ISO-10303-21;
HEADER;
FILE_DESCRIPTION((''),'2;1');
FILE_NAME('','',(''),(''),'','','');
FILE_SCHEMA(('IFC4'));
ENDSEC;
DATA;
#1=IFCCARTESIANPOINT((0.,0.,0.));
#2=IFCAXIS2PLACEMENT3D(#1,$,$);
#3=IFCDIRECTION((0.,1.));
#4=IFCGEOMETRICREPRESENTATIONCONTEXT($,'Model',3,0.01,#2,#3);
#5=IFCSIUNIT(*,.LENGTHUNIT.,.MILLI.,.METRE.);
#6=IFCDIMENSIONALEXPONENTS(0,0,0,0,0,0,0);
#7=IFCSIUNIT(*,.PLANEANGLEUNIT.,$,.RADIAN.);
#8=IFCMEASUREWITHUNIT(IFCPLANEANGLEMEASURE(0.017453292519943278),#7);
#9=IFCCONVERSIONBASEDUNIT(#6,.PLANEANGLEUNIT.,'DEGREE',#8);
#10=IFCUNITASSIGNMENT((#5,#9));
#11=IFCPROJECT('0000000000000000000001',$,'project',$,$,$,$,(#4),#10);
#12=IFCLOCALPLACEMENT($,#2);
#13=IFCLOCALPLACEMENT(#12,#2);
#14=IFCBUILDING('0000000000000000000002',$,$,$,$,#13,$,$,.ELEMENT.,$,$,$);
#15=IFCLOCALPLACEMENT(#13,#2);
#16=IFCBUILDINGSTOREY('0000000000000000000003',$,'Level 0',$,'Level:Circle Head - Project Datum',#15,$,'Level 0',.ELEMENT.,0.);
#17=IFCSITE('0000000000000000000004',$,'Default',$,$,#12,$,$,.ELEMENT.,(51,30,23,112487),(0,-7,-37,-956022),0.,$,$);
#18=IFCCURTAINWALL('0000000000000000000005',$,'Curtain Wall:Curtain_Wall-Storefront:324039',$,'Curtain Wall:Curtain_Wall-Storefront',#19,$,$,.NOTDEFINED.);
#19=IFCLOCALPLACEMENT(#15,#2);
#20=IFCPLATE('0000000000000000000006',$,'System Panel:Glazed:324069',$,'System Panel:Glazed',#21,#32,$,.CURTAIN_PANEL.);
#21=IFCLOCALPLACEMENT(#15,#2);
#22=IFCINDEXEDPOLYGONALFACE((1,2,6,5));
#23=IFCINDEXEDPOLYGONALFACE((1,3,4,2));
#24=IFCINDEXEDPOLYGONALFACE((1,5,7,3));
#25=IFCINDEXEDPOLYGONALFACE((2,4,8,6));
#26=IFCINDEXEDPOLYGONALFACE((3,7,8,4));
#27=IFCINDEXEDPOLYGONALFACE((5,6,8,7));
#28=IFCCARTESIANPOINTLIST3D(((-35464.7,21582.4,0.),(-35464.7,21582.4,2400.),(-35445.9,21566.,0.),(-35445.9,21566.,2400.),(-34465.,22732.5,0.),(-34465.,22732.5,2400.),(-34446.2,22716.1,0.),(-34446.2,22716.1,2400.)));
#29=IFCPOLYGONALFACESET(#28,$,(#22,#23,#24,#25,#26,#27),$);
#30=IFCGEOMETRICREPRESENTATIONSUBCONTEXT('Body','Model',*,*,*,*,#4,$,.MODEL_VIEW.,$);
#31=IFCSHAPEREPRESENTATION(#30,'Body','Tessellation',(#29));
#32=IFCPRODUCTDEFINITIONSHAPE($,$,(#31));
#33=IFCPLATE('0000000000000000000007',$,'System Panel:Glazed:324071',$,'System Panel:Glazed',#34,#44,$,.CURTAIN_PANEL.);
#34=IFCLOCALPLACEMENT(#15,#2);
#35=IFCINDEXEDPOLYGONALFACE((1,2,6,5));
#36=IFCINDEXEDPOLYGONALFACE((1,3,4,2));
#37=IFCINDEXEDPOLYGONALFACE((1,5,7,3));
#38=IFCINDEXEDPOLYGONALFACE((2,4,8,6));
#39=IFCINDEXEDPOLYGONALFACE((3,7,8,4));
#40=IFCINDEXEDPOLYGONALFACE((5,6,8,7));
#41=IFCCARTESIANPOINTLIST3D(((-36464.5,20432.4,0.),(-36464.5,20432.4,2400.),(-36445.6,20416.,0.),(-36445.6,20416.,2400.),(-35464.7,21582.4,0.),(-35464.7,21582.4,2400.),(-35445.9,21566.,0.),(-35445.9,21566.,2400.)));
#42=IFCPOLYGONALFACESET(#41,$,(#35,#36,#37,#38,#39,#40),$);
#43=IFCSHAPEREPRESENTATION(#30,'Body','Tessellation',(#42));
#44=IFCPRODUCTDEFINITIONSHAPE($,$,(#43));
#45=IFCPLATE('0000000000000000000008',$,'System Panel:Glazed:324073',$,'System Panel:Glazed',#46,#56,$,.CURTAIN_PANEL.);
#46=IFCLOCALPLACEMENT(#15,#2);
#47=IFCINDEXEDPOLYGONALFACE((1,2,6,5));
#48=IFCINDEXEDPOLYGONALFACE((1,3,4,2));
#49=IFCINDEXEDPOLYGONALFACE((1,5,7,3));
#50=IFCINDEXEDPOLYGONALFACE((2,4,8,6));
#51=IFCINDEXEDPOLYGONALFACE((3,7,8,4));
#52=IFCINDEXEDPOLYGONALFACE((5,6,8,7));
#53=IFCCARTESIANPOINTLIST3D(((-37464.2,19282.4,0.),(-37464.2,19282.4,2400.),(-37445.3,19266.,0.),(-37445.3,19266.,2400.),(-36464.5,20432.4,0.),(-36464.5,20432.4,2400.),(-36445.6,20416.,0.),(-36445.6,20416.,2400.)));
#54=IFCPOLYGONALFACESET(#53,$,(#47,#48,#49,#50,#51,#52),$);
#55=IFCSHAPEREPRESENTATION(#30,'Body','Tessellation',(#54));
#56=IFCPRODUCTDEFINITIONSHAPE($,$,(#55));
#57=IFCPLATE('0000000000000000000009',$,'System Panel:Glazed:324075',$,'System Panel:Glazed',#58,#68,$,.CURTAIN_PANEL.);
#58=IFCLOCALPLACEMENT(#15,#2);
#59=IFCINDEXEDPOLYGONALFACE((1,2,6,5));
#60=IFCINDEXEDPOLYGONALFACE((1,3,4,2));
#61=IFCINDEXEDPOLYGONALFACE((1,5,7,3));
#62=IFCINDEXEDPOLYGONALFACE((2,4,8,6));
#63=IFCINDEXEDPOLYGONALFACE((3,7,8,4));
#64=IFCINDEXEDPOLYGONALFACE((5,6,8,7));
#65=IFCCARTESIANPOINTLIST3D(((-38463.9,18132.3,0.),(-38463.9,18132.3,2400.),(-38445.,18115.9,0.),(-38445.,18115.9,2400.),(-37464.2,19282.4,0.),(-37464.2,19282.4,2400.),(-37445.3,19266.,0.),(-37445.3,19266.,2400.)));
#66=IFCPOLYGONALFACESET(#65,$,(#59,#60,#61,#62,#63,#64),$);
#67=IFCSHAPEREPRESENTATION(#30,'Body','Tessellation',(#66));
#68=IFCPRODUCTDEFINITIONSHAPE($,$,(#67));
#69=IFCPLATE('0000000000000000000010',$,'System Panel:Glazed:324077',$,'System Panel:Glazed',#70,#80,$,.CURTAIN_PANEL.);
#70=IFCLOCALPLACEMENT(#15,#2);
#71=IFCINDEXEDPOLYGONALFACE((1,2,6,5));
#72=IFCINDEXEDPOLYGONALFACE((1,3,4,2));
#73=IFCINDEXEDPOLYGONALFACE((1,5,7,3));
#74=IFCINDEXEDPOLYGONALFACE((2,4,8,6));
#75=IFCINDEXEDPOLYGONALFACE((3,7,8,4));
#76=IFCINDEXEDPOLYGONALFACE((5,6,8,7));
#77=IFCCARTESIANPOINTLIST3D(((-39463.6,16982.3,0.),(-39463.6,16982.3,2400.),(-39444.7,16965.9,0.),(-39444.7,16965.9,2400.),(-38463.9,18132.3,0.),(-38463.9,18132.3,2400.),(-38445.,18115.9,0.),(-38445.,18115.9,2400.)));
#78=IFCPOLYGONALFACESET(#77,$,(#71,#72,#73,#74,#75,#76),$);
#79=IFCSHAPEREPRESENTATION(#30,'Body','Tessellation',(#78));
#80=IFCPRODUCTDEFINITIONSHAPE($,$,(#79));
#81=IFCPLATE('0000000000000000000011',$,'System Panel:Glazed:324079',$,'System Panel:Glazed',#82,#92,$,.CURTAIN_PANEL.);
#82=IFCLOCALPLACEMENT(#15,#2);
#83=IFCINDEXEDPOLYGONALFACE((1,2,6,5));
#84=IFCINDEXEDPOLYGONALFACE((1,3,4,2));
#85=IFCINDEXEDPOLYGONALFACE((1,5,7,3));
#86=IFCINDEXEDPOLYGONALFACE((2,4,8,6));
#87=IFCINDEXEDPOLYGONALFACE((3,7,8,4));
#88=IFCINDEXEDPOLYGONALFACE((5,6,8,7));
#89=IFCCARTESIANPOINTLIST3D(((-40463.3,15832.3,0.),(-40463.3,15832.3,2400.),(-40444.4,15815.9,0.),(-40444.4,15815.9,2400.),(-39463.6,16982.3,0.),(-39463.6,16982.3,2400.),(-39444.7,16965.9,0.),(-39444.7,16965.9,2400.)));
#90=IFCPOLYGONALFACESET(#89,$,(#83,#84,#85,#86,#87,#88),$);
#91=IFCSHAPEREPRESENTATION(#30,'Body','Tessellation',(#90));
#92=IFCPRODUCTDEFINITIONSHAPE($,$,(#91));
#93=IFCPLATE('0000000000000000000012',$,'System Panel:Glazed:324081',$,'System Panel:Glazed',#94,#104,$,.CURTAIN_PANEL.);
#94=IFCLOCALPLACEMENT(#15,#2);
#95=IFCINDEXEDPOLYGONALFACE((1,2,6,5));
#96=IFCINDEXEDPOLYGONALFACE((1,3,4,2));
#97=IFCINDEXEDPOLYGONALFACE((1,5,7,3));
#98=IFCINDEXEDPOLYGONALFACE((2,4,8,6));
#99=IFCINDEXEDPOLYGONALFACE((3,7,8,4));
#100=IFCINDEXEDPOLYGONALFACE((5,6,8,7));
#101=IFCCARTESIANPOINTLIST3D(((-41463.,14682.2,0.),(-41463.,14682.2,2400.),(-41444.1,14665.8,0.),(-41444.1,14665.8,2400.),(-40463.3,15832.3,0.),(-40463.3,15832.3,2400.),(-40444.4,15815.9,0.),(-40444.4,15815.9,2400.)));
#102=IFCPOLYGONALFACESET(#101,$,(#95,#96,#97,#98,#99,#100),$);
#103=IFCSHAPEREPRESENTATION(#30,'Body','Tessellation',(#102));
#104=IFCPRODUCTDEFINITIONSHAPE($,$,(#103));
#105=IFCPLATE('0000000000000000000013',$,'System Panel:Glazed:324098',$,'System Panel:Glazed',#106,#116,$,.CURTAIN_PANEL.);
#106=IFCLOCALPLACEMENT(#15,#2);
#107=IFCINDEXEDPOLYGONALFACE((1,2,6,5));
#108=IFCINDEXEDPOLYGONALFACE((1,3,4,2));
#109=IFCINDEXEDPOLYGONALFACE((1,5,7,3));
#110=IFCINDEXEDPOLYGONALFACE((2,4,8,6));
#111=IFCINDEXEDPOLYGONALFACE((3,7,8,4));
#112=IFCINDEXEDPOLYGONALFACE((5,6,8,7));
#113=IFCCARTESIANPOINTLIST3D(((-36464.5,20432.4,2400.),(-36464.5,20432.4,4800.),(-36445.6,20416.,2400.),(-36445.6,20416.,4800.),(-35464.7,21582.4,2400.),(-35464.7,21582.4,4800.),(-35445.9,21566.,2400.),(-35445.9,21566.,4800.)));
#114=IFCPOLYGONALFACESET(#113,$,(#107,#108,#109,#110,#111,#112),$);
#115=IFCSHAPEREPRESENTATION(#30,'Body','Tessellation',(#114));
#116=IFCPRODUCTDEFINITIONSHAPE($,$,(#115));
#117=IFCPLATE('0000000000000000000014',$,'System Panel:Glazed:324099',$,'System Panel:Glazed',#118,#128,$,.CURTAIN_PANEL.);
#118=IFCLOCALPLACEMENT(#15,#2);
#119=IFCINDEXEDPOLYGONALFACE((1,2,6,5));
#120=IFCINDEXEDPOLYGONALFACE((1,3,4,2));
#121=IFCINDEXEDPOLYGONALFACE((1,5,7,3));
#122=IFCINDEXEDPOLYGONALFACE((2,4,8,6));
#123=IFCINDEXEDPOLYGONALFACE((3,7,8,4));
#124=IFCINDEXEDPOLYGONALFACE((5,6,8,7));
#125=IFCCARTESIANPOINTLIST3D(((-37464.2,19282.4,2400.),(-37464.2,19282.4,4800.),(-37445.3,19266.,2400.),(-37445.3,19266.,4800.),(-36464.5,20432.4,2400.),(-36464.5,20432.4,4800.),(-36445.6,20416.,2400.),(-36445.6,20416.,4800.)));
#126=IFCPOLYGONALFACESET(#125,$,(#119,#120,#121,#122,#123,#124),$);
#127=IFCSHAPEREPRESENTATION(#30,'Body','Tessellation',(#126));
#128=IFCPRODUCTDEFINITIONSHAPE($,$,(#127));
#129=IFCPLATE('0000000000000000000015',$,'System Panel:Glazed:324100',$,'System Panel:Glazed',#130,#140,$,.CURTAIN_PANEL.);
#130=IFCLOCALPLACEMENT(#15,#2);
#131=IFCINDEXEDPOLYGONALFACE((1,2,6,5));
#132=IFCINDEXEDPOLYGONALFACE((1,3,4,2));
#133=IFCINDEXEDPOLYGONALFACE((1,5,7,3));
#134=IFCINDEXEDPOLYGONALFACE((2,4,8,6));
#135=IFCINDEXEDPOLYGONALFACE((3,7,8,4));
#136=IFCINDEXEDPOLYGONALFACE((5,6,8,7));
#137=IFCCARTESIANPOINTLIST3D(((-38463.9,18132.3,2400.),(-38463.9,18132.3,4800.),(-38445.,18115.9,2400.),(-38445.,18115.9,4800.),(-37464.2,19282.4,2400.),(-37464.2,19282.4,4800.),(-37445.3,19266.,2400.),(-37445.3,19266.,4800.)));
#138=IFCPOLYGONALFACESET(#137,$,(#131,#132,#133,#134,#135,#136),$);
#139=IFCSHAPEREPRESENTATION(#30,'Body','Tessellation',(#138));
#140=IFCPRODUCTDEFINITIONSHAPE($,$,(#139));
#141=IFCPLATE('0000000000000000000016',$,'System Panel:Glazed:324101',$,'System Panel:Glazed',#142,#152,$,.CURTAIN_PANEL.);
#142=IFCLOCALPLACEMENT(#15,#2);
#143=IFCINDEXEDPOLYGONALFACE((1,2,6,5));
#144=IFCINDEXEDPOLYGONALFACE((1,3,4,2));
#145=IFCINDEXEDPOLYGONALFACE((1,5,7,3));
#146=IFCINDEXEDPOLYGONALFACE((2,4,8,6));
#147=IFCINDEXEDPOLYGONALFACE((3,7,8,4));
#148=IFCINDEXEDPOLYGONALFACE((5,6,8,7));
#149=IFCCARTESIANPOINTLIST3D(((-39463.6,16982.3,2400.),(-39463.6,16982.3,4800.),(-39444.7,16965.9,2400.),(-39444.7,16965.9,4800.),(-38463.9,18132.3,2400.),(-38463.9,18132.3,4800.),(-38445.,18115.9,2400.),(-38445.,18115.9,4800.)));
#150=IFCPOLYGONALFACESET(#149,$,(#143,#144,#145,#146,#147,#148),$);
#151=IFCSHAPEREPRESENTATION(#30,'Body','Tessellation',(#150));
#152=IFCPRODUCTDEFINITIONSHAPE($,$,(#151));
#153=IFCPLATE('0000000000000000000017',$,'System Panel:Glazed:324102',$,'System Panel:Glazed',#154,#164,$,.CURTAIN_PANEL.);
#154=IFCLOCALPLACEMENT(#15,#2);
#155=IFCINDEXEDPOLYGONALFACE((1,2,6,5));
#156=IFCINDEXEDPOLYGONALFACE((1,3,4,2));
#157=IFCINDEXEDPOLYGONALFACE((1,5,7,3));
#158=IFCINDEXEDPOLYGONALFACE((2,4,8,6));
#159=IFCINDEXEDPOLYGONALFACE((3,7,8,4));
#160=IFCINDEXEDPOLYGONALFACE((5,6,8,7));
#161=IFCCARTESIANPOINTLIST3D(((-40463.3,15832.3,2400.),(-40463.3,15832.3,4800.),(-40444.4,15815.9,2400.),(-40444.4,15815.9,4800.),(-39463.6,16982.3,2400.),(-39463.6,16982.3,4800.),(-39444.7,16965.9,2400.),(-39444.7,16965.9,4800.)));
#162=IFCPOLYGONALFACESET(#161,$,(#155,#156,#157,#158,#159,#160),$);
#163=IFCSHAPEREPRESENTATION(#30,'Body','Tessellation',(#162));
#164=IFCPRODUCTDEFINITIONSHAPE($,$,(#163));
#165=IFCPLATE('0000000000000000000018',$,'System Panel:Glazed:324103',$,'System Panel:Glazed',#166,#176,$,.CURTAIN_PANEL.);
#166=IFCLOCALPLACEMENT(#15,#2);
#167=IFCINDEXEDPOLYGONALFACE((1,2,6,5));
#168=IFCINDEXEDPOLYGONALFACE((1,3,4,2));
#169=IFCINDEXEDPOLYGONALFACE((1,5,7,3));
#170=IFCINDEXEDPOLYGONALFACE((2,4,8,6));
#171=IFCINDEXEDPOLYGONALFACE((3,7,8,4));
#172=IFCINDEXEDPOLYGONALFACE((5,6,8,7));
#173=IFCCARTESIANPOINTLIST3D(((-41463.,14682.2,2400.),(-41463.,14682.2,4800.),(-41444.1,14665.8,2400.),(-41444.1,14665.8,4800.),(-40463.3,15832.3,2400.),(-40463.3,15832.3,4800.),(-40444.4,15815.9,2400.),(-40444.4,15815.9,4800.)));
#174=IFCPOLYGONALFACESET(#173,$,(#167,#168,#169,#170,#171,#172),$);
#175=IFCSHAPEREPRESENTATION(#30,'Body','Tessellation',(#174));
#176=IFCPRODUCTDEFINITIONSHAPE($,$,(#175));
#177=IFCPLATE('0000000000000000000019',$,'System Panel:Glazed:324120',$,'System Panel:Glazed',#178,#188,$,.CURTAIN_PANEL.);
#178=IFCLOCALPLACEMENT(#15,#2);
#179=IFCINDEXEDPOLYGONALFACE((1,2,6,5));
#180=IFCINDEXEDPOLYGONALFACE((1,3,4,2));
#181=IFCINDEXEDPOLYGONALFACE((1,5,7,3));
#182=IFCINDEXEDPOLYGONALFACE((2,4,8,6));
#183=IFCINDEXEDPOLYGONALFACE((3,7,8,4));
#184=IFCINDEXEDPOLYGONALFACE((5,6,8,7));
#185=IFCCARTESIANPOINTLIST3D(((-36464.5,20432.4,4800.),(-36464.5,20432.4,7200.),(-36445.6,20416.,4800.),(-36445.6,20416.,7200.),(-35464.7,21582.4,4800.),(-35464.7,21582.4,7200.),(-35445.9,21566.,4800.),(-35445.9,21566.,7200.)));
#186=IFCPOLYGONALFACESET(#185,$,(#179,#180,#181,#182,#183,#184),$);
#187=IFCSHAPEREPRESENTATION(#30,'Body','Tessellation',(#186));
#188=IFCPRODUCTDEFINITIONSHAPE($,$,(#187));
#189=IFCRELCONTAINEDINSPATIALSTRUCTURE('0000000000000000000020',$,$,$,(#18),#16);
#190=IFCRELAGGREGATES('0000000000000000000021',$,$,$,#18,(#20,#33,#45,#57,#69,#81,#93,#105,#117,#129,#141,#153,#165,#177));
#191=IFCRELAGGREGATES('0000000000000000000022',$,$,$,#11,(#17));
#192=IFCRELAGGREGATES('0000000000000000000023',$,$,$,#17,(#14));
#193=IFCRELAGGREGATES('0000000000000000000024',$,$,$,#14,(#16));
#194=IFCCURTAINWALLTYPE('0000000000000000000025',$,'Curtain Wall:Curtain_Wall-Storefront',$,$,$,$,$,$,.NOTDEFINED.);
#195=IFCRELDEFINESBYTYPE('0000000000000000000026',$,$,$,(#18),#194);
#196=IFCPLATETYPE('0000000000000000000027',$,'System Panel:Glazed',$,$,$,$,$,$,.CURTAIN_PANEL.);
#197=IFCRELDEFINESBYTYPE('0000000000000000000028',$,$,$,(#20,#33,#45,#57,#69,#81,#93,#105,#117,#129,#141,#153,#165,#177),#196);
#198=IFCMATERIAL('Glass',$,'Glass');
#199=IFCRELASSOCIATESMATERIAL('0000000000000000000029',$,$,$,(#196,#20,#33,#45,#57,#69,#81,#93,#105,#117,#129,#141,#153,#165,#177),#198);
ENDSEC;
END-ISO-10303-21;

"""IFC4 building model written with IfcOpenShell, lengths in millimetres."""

from ifc_helpers import new_model, entity, si_unit, converted_unit, direction, frame, origin, place, context, subcontext, project, spatial, indexed_curve, outline, extrude, source, transform, mapped, material, type_object, type_shapes, element, aggregate, save


model = new_model("IFC4")

# Units and contexts
model_context = context("Model", 3, precision=0.01, world=origin(), true_north=direction((0.0, 1.0)))
body_context = subcontext(model_context, "Body", "Model", "MODEL_VIEW")
ifc_project = project(units=[si_unit("LENGTHUNIT", "METRE", prefix="MILLI"), converted_unit("PLANEANGLEUNIT", "DEGREE", entity("IfcPlaneAngleMeasure", 0.017453292519943278), si_unit("PLANEANGLEUNIT", "RADIAN"), dimensions=[0, 0, 0, 0, 0, 0, 0])], contexts=[model_context])

# Site, building, storey
site_placement = place(None, origin())
site = spatial("IfcSite", under=ifc_project, at=site_placement, Name="Default", CompositionType="ELEMENT", RefLatitude=(51, 30, 23, 112487), RefLongitude=(0, -7, -37, -956022), RefElevation=0.0)
building_placement = place(site_placement, origin())
building = spatial("IfcBuilding", under=site, at=building_placement, CompositionType="ELEMENT")
storey_placement = place(building_placement, origin())
storey = spatial("IfcBuildingStorey", under=building, at=storey_placement, Name="Level 0", ObjectType="Level:Circle Head - Project Datum", LongName="Level 0", CompositionType="ELEMENT", Elevation=0.0)

# Curtain wall, plates
curtain_wall_type = type_object("IfcCurtainWallType", Name="Curtain Wall:Curtain_Wall-Storefront", PredefinedType="NOTDEFINED")
curtain_wall_placement = place(storey_placement, origin())
curtain_wall = element("IfcCurtainWall", 1, at=curtain_wall_placement, inside=storey, type_object=curtain_wall_type, Name="Curtain Wall:Curtain_Wall-Storefront:324039", ObjectType="Curtain Wall:Curtain_Wall-Storefront", PredefinedType="NOTDEFINED")
ifc_material = material(Name="Glass", Category="Glass")
plate_type_1 = type_object("IfcPlateType", Name="System Panel:Glazed", PredefinedType="CURTAIN_PANEL", material=ifc_material)
shared_shape_1 = source(origin(), body_context, "Body", "SweptSolid", [
    extrude(outline(indexed_curve([(-12.5, -761.9), (12.5, -761.9), (12.5, 761.9), (-12.5, 761.9), (-12.5, -761.9)], self_intersect=False)), frame((0.0, 37.0, 0.0), z_axis=(0.0, 0.0, 1.0), x_axis=(0.0, 1.0, 0.0)), (0.0, 0.0, 1.0), 2400.0),
])
type_shapes(plate_type_1, [shared_shape_1])
plate_1_placement = place(curtain_wall_placement, frame((-34983.4, 22173.5, 0.0), z_axis=(0.0, 0.0, 1.0), x_axis=(-0.656059, -0.75471, 0.0)))
plate_1 = element("IfcPlate", 2, at=plate_1_placement, type_object=plate_type_1, material=ifc_material, Name="System Panel:Glazed:324069", ObjectType="System Panel:Glazed", PredefinedType="CURTAIN_PANEL", context=body_context, shape_type="MappedRepresentation", body=[
    mapped(shared_shape_1, transform((0.0, 0.0, 0.0), scale=1.0)),
])
plate_2_placement = place(curtain_wall_placement, frame((-35983.1, 21023.5, 0.0), z_axis=(0.0, 0.0, 1.0), x_axis=(-0.656059, -0.75471, 0.0)))
plate_2 = element("IfcPlate", 3, at=plate_2_placement, type_object=plate_type_1, material=ifc_material, Name="System Panel:Glazed:324071", ObjectType="System Panel:Glazed", PredefinedType="CURTAIN_PANEL", context=body_context, shape_type="MappedRepresentation", body=[
    mapped(shared_shape_1, transform((0.0, 0.0, 0.0), scale=1.0)),
])
plate_3_placement = place(curtain_wall_placement, frame((-36982.8, 19873.5, 0.0), z_axis=(0.0, 0.0, 1.0), x_axis=(-0.656059, -0.75471, 0.0)))
plate_3 = element("IfcPlate", 4, at=plate_3_placement, type_object=plate_type_1, material=ifc_material, Name="System Panel:Glazed:324073", ObjectType="System Panel:Glazed", PredefinedType="CURTAIN_PANEL", context=body_context, shape_type="MappedRepresentation", body=[
    mapped(shared_shape_1, transform((0.0, 0.0, 0.0), scale=1.0)),
])
plate_4_placement = place(curtain_wall_placement, frame((-37982.5, 18723.4, 0.0), z_axis=(0.0, 0.0, 1.0), x_axis=(-0.656059, -0.75471, 0.0)))
plate_4 = element("IfcPlate", 5, at=plate_4_placement, type_object=plate_type_1, material=ifc_material, Name="System Panel:Glazed:324075", ObjectType="System Panel:Glazed", PredefinedType="CURTAIN_PANEL", context=body_context, shape_type="MappedRepresentation", body=[
    mapped(shared_shape_1, transform((0.0, 0.0, 0.0), scale=1.0)),
])
plate_5_placement = place(curtain_wall_placement, frame((-38982.2, 17573.4, 0.0), z_axis=(0.0, 0.0, 1.0), x_axis=(-0.656059, -0.75471, 0.0)))
plate_5 = element("IfcPlate", 6, at=plate_5_placement, type_object=plate_type_1, material=ifc_material, Name="System Panel:Glazed:324077", ObjectType="System Panel:Glazed", PredefinedType="CURTAIN_PANEL", context=body_context, shape_type="MappedRepresentation", body=[
    mapped(shared_shape_1, transform((0.0, 0.0, 0.0), scale=1.0)),
])
plate_6_placement = place(curtain_wall_placement, frame((-39981.9, 16423.4, 0.0), z_axis=(0.0, 0.0, 1.0), x_axis=(-0.656059, -0.75471, 0.0)))
plate_6 = element("IfcPlate", 7, at=plate_6_placement, type_object=plate_type_1, material=ifc_material, Name="System Panel:Glazed:324079", ObjectType="System Panel:Glazed", PredefinedType="CURTAIN_PANEL", context=body_context, shape_type="MappedRepresentation", body=[
    mapped(shared_shape_1, transform((0.0, 0.0, 0.0), scale=1.0)),
])
plate_7_placement = place(curtain_wall_placement, frame((-40981.6, 15273.3, 0.0), z_axis=(0.0, 0.0, 1.0), x_axis=(-0.656059, -0.75471, 0.0)))
plate_7 = element("IfcPlate", 8, at=plate_7_placement, type_object=plate_type_1, material=ifc_material, Name="System Panel:Glazed:324081", ObjectType="System Panel:Glazed", PredefinedType="CURTAIN_PANEL", context=body_context, shape_type="MappedRepresentation", body=[
    mapped(shared_shape_1, transform((0.0, 0.0, 0.0), scale=1.0)),
])
plate_8_placement = place(curtain_wall_placement, frame((-35983.1, 21023.5, 2400.0), z_axis=(0.0, 0.0, 1.0), x_axis=(-0.656059, -0.75471, 0.0)))
plate_8 = element("IfcPlate", 9, at=plate_8_placement, type_object=plate_type_1, material=ifc_material, Name="System Panel:Glazed:324098", ObjectType="System Panel:Glazed", PredefinedType="CURTAIN_PANEL", context=body_context, shape_type="MappedRepresentation", body=[
    mapped(shared_shape_1, transform((0.0, 0.0, 0.0), scale=1.0)),
])
plate_9_placement = place(curtain_wall_placement, frame((-36982.8, 19873.5, 2400.0), z_axis=(0.0, 0.0, 1.0), x_axis=(-0.656059, -0.75471, 0.0)))
plate_9 = element("IfcPlate", 10, at=plate_9_placement, type_object=plate_type_1, material=ifc_material, Name="System Panel:Glazed:324099", ObjectType="System Panel:Glazed", PredefinedType="CURTAIN_PANEL", context=body_context, shape_type="MappedRepresentation", body=[
    mapped(shared_shape_1, transform((0.0, 0.0, 0.0), scale=1.0)),
])
plate_10_placement = place(curtain_wall_placement, frame((-37982.5, 18723.4, 2400.0), z_axis=(0.0, 0.0, 1.0), x_axis=(-0.656059, -0.75471, 0.0)))
plate_10 = element("IfcPlate", 11, at=plate_10_placement, type_object=plate_type_1, material=ifc_material, Name="System Panel:Glazed:324100", ObjectType="System Panel:Glazed", PredefinedType="CURTAIN_PANEL", context=body_context, shape_type="MappedRepresentation", body=[
    mapped(shared_shape_1, transform((0.0, 0.0, 0.0), scale=1.0)),
])
plate_11_placement = place(curtain_wall_placement, frame((-38982.2, 17573.4, 2400.0), z_axis=(0.0, 0.0, 1.0), x_axis=(-0.656059, -0.75471, 0.0)))
plate_11 = element("IfcPlate", 12, at=plate_11_placement, type_object=plate_type_1, material=ifc_material, Name="System Panel:Glazed:324101", ObjectType="System Panel:Glazed", PredefinedType="CURTAIN_PANEL", context=body_context, shape_type="MappedRepresentation", body=[
    mapped(shared_shape_1, transform((0.0, 0.0, 0.0), scale=1.0)),
])
plate_12_placement = place(curtain_wall_placement, frame((-39981.9, 16423.4, 2400.0), z_axis=(0.0, 0.0, 1.0), x_axis=(-0.656059, -0.75471, 0.0)))
plate_12 = element("IfcPlate", 13, at=plate_12_placement, type_object=plate_type_1, material=ifc_material, Name="System Panel:Glazed:324102", ObjectType="System Panel:Glazed", PredefinedType="CURTAIN_PANEL", context=body_context, shape_type="MappedRepresentation", body=[
    mapped(shared_shape_1, transform((0.0, 0.0, 0.0), scale=1.0)),
])
plate_13_placement = place(curtain_wall_placement, frame((-40981.6, 15273.3, 2400.0), z_axis=(0.0, 0.0, 1.0), x_axis=(-0.656059, -0.75471, 0.0)))
plate_13 = element("IfcPlate", 14, at=plate_13_placement, type_object=plate_type_1, material=ifc_material, Name="System Panel:Glazed:324103", ObjectType="System Panel:Glazed", PredefinedType="CURTAIN_PANEL", context=body_context, shape_type="MappedRepresentation", body=[
    mapped(shared_shape_1, transform((0.0, 0.0, 0.0), scale=1.0)),
])
plate_14_placement = place(curtain_wall_placement, frame((-35983.1, 21023.5, 4800.0), z_axis=(0.0, 0.0, 1.0), x_axis=(-0.656059, -0.75471, 0.0)))
plate_14 = element("IfcPlate", 15, at=plate_14_placement, type_object=plate_type_1, material=ifc_material, Name="System Panel:Glazed:324120", ObjectType="System Panel:Glazed", PredefinedType="CURTAIN_PANEL", context=body_context, shape_type="MappedRepresentation", body=[
    mapped(shared_shape_1, transform((0.0, 0.0, 0.0), scale=1.0)),
])
aggregate(curtain_wall, [plate_1, plate_2, plate_3, plate_4, plate_5, plate_6, plate_7, plate_8, plate_9, plate_10, plate_11, plate_12, plate_13, plate_14])

save(model, "model.ifc")
